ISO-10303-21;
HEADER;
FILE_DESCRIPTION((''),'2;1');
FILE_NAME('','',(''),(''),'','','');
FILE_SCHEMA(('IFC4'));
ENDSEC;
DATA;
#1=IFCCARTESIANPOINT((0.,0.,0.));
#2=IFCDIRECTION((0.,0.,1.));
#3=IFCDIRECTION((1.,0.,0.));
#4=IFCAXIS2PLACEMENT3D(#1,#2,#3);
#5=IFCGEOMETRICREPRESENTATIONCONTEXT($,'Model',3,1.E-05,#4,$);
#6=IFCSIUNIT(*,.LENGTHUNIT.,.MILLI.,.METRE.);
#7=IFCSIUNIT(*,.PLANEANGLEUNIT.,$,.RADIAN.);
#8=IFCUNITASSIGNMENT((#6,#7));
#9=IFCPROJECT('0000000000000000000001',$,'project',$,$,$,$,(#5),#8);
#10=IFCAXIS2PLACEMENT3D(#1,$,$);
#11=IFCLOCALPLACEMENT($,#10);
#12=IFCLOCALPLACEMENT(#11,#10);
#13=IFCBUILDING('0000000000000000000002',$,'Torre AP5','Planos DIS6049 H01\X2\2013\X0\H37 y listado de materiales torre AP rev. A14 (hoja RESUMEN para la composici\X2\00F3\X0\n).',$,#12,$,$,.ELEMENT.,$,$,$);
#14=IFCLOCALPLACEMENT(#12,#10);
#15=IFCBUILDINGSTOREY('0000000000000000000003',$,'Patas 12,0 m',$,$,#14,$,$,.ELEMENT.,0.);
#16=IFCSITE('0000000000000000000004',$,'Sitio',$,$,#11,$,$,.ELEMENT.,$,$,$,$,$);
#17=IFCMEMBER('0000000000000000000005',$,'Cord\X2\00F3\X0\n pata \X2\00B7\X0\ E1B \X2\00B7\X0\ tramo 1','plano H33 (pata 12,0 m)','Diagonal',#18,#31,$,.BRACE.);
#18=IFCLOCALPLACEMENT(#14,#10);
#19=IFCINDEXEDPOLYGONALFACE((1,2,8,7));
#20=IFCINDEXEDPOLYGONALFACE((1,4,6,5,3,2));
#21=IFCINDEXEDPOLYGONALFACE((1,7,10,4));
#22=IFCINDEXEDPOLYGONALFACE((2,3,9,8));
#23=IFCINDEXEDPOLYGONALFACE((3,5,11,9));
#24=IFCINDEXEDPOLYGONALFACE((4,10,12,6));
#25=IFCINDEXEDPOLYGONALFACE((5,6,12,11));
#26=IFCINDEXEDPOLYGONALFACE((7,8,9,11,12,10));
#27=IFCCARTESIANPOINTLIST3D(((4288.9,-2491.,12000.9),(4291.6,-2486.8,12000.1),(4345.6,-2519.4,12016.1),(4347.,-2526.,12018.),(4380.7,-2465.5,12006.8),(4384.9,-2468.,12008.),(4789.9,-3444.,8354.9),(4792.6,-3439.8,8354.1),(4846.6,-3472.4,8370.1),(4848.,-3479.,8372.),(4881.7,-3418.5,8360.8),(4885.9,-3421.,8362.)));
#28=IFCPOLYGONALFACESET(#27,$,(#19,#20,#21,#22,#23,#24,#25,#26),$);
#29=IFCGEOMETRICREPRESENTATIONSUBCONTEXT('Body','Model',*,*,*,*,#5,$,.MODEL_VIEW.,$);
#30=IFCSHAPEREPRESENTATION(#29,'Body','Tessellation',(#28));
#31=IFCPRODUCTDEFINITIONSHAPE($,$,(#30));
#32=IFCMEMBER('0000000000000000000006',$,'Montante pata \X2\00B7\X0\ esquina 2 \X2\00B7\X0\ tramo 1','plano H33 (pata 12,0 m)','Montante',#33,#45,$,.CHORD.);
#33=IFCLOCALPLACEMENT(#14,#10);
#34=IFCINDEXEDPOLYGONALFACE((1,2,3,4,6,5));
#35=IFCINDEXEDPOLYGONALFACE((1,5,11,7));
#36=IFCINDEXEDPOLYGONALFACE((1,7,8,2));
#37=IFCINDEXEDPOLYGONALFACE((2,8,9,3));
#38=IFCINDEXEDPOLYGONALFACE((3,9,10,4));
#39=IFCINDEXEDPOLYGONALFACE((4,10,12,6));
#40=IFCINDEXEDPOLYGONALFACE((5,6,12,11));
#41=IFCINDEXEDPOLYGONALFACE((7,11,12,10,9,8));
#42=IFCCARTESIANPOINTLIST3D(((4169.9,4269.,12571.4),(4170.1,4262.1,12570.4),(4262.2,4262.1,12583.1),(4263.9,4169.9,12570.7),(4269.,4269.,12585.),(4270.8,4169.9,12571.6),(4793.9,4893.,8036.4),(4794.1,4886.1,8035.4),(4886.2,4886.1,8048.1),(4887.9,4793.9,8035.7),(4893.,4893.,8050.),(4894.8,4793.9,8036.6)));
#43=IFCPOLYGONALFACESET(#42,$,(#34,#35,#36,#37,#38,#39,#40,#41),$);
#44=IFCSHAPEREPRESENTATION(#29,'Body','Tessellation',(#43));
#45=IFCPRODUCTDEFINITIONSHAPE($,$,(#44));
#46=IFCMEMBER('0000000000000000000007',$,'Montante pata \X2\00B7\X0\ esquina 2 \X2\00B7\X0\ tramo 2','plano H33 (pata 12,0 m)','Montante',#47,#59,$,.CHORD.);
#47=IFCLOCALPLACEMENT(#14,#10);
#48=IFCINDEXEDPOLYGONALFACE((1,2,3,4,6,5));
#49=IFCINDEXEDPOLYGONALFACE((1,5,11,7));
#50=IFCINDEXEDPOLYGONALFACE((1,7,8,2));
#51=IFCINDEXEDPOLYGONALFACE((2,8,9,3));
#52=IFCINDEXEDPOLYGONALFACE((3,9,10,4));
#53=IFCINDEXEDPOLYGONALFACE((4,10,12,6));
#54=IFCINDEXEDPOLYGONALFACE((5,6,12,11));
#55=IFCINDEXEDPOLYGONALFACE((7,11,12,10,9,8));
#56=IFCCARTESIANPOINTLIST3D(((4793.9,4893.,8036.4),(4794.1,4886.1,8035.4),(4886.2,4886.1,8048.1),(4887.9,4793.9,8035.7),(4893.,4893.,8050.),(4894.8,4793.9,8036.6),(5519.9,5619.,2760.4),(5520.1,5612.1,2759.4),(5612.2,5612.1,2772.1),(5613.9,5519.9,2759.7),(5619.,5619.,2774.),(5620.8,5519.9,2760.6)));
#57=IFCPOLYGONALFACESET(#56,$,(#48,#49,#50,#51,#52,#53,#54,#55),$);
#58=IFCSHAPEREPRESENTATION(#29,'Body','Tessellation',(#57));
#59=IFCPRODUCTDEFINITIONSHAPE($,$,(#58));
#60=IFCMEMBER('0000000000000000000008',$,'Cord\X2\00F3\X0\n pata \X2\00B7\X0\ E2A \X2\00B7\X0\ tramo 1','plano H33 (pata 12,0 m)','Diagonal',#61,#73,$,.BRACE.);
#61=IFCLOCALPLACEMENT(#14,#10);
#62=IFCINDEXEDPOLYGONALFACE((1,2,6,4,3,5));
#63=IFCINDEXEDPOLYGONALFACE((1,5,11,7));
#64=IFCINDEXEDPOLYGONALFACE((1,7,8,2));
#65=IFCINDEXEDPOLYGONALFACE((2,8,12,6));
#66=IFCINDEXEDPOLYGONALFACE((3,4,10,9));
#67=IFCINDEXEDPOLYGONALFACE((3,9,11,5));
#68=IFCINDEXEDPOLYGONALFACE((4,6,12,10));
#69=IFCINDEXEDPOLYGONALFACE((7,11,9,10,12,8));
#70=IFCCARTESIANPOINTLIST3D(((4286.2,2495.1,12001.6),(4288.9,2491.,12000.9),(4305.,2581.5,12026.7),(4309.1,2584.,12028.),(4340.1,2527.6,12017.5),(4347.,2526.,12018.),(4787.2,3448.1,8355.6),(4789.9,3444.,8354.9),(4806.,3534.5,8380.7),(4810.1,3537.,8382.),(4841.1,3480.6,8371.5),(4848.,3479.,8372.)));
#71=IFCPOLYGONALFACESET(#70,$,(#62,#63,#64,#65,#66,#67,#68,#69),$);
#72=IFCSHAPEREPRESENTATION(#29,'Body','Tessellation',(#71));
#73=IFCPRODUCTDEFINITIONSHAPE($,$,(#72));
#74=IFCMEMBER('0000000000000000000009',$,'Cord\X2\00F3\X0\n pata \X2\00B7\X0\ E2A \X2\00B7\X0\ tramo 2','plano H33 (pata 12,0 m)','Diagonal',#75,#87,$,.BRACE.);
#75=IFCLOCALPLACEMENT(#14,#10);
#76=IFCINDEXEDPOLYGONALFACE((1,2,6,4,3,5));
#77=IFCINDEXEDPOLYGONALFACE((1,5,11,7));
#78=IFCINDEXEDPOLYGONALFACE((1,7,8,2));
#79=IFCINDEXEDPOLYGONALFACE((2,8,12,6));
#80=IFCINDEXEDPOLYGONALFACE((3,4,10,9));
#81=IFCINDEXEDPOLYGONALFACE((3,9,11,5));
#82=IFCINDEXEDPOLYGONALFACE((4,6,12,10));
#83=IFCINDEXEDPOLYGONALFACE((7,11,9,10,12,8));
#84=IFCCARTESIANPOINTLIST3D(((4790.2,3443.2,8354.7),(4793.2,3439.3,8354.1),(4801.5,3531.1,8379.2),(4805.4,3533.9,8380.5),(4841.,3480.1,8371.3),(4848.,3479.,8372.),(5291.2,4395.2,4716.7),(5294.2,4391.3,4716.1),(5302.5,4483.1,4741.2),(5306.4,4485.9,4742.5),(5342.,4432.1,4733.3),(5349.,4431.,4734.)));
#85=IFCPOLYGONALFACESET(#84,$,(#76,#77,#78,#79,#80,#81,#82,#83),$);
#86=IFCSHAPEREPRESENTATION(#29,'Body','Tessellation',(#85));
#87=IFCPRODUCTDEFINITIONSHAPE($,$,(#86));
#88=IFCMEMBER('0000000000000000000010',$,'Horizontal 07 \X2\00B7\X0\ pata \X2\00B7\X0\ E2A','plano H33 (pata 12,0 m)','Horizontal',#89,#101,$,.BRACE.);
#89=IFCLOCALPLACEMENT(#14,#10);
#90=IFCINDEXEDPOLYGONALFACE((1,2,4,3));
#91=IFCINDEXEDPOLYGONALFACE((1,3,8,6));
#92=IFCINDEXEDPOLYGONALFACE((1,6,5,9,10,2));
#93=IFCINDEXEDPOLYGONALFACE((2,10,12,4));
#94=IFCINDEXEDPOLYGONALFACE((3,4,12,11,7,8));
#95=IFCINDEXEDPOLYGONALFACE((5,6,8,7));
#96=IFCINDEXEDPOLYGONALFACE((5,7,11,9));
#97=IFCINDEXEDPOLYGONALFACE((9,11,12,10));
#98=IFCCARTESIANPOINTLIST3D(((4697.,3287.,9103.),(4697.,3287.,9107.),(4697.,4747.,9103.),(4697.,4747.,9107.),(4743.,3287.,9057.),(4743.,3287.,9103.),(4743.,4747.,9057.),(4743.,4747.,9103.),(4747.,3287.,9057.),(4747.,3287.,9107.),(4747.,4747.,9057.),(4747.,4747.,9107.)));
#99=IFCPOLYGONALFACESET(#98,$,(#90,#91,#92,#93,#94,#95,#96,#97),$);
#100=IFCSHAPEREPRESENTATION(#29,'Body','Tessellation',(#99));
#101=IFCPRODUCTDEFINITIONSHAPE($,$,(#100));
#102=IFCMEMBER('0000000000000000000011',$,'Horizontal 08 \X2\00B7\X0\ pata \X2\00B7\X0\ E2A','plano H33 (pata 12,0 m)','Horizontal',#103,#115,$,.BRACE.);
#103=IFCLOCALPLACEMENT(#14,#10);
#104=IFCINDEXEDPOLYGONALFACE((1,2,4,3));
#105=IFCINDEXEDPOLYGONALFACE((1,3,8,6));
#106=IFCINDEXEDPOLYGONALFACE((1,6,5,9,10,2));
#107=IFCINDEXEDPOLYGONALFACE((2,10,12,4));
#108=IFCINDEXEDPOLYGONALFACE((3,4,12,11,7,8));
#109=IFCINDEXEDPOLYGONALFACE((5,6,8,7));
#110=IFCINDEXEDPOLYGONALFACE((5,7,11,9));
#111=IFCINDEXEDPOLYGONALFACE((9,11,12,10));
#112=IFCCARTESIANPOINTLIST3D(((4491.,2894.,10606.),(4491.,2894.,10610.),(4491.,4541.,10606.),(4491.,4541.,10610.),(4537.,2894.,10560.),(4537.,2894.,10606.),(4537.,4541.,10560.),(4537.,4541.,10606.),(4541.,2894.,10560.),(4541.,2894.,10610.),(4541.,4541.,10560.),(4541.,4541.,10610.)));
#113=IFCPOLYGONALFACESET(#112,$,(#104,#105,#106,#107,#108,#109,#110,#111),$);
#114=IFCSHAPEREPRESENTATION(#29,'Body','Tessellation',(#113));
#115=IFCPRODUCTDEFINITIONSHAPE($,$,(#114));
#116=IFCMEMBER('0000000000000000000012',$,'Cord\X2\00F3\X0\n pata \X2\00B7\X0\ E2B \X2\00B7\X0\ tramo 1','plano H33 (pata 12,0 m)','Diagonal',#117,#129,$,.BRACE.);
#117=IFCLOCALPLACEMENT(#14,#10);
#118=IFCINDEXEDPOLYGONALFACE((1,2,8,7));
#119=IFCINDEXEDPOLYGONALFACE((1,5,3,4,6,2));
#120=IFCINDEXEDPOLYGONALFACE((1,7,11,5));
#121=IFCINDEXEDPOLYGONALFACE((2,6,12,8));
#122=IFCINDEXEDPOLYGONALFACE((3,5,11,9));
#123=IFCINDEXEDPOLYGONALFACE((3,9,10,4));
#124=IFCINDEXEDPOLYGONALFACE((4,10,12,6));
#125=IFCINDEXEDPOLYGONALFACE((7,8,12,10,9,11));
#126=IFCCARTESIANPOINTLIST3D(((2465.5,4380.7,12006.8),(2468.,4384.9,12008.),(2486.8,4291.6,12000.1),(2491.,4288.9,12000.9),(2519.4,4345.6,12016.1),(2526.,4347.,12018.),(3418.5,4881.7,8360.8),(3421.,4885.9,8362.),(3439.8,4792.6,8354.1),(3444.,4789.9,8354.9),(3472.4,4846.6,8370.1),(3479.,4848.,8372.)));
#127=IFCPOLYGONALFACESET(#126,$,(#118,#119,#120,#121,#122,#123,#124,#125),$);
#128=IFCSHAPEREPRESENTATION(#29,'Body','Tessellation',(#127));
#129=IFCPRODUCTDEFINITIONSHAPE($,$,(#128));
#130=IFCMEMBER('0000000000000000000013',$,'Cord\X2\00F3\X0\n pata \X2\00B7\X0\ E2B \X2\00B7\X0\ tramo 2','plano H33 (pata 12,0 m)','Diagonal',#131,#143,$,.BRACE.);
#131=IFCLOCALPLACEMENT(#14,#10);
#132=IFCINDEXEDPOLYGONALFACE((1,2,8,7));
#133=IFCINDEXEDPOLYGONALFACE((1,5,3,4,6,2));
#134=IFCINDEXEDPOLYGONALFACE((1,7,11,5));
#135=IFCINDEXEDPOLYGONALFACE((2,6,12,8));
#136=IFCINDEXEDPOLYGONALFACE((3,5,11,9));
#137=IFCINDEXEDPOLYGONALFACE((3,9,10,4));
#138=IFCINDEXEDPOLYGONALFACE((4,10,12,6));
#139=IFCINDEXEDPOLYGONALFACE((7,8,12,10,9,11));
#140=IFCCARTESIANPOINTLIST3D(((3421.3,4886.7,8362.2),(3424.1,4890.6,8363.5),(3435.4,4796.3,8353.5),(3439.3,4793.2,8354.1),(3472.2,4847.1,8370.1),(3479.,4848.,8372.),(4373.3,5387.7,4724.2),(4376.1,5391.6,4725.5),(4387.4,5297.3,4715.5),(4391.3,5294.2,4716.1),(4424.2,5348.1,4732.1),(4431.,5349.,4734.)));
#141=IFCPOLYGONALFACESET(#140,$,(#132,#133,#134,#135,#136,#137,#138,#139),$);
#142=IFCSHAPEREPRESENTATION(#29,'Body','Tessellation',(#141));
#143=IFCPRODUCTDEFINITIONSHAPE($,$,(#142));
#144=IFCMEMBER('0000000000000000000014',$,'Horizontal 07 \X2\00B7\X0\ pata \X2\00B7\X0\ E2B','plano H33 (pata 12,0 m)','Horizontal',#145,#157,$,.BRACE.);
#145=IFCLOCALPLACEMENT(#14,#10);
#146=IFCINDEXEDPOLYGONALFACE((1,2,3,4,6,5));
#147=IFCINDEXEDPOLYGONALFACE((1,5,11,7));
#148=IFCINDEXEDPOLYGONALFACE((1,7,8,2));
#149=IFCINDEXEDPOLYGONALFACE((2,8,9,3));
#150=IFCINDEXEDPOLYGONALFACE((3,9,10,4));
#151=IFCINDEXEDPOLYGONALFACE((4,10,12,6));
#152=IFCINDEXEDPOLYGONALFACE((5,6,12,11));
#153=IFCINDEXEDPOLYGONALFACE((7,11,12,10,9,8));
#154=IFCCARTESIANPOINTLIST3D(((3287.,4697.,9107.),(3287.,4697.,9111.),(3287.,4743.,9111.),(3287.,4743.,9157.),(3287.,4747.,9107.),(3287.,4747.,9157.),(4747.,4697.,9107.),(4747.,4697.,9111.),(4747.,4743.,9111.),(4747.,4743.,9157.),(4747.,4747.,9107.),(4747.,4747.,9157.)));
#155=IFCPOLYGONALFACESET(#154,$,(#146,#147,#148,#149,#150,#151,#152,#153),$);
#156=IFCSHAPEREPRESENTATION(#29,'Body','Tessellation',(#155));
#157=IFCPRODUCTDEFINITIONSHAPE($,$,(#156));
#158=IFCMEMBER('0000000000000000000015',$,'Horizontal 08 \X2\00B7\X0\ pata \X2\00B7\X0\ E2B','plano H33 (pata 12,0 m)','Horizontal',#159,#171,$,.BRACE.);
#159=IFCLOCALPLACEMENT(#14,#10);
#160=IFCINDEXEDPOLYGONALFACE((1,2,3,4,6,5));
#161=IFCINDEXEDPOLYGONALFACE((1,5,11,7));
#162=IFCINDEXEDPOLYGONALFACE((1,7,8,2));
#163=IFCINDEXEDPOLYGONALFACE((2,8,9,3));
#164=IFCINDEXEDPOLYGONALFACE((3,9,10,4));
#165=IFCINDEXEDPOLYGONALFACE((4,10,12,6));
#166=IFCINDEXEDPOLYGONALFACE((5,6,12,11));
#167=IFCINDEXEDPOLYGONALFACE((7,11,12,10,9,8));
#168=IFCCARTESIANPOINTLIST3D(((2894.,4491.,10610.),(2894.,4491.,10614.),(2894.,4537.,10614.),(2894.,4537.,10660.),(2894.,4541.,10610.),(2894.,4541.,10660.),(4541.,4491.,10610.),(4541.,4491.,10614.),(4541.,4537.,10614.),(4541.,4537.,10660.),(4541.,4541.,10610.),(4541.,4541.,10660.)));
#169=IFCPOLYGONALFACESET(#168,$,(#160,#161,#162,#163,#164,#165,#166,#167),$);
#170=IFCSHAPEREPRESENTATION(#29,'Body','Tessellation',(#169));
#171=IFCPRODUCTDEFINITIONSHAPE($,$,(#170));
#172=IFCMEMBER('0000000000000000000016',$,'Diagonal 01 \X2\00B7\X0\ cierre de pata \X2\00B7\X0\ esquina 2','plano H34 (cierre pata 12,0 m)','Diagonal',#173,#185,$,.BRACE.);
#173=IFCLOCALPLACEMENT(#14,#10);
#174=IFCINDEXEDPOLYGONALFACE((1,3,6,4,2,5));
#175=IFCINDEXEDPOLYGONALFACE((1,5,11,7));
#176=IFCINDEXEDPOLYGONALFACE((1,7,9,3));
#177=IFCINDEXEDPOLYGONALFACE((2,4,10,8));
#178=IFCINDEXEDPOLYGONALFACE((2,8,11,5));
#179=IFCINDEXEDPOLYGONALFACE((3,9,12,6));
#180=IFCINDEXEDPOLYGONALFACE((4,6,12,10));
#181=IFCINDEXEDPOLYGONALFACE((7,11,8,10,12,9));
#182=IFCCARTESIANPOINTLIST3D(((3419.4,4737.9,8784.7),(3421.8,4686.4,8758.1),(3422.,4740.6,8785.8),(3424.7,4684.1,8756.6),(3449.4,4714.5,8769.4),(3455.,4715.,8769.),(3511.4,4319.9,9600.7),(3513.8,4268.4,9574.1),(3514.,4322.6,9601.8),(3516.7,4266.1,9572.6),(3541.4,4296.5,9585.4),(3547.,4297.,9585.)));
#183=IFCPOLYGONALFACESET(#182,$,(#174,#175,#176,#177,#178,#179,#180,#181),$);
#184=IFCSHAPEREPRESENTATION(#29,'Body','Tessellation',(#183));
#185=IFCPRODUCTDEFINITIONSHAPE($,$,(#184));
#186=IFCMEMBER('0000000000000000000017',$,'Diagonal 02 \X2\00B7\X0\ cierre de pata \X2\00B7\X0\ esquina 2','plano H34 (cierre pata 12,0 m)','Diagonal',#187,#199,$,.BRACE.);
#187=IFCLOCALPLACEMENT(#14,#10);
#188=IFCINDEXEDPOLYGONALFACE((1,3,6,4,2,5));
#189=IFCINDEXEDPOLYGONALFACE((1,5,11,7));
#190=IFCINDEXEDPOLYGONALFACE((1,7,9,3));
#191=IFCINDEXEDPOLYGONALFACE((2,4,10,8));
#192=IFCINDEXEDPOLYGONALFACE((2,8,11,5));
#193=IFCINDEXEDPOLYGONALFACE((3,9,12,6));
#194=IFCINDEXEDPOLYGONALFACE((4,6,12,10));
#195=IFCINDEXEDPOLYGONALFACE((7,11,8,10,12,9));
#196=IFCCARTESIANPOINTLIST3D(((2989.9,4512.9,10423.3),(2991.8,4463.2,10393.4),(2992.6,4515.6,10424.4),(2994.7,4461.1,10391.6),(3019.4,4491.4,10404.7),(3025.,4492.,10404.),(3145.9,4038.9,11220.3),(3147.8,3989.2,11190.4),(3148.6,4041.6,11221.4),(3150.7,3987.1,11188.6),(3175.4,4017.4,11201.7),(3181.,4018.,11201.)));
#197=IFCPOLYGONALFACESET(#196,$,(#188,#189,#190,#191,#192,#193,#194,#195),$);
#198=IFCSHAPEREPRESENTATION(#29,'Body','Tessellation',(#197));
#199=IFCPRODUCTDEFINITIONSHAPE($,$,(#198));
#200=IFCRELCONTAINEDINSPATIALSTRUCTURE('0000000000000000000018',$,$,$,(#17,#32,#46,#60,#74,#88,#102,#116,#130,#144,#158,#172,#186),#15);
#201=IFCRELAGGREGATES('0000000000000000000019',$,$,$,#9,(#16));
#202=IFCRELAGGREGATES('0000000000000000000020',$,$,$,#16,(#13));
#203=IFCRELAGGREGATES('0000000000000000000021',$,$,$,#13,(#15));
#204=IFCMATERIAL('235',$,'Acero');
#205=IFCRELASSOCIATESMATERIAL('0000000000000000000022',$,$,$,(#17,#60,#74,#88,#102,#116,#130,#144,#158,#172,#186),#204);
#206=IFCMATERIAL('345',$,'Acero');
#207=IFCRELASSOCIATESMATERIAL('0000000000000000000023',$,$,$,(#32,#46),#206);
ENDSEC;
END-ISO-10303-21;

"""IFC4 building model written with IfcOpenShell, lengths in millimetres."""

from ifc_helpers import new_model, si_unit, frame, frame_2d, origin, origin_with_axes, place, context, subcontext, project, spatial, l_section, extrude, material, element, save


model = new_model("IFC4")

# Units and contexts
model_context = context("Model", 3, precision=1e-05, world=origin_with_axes())
body_context = subcontext(model_context, "Body", "Model", "MODEL_VIEW")
ifc_project = project(units=[si_unit("LENGTHUNIT", "METRE", prefix="MILLI"), si_unit("PLANEANGLEUNIT", "RADIAN")], contexts=[model_context])

# Site, building, storey
site_placement = place(None, origin())
site = spatial("IfcSite", under=ifc_project, at=site_placement, Name="Sitio", CompositionType="ELEMENT")
building_placement = place(site_placement, origin())
building = spatial("IfcBuilding", under=site, at=building_placement, Name="Torre AP5", Description="Planos DIS6049 H01–H37 y listado de materiales torre AP rev. A14 (hoja RESUMEN para la composición).", CompositionType="ELEMENT")
storey_placement = place(building_placement, origin())
storey = spatial("IfcBuildingStorey", under=building, at=storey_placement, Name="Patas 12,0 m", CompositionType="ELEMENT", Elevation=0.0)

# Members
ifc_material_1 = material(Name="235", Category="Acero")
member_1_placement = place(storey_placement, frame((4347.0, -2526.0, 12018.0), z_axis=(0.131785, -0.250681, -0.959058), x_axis=(-0.83048, 0.500329, -0.244894)))
element("IfcMember", 1, at=member_1_placement, inside=storey, material=ifc_material_1, Name="Cordón pata · E1B · tramo 1", Description="plano H33 (pata 12,0 m)", ObjectType="Diagonal", PredefinedType="BRACE", context=body_context, shape_type="SweptSolid", body=[
    extrude(l_section(Depth=70.0, Width=70.0, Thickness=5.0, at=frame_2d((35.0, 35.0))), None, (0.0, 0.0, 1.0), 3801.6),
])
ifc_material_2 = material(Name="345", Category="Acero")
member_2_placement = place(storey_placement, frame((4269.0, 4269.0, 12585.0), z_axis=(0.135063, 0.135063, -0.981588), x_axis=(0.018411, -0.990837, -0.133802)))
element("IfcMember", 2, at=member_2_placement, inside=storey, material=ifc_material_2, Name="Montante pata · esquina 2 · tramo 1", Description="plano H33 (pata 12,0 m)", ObjectType="Montante", PredefinedType="CHORD", context=body_context, shape_type="SweptSolid", body=[
    extrude(l_section(Depth=100.0, Width=100.0, Thickness=7.0, at=frame_2d((50.0, 50.0))), None, (0.0, 0.0, 1.0), 4620.1),
])
member_3_placement = place(storey_placement, frame((4893.0, 4893.0, 8050.0), z_axis=(0.13507, 0.13507, -0.981586), x_axis=(0.018413, -0.990836, -0.13381)))
element("IfcMember", 3, at=member_3_placement, inside=storey, material=ifc_material_2, Name="Montante pata · esquina 2 · tramo 2", Description="plano H33 (pata 12,0 m)", ObjectType="Montante", PredefinedType="CHORD", context=body_context, shape_type="SweptSolid", body=[
    extrude(l_section(Depth=100.0, Width=100.0, Thickness=7.0, at=frame_2d((50.0, 50.0))), None, (0.0, 0.0, 1.0), 5375.0),
])
member_4_placement = place(storey_placement, frame((4347.0, 2526.0, 12018.0), z_axis=(0.131785, 0.250681, -0.959058), x_axis=(-0.83048, -0.500329, -0.244894)))
element("IfcMember", 4, at=member_4_placement, inside=storey, material=ifc_material_1, Name="Cordón pata · E2A · tramo 1", Description="plano H33 (pata 12,0 m)", ObjectType="Diagonal", PredefinedType="BRACE", context=body_context, shape_type="SweptSolid", body=[
    extrude(l_section(Depth=70.0, Width=70.0, Thickness=5.0, at=frame_2d((35.0, 35.0))), None, (0.0, 0.0, 1.0), 3801.6),
])
member_5_placement = place(storey_placement, frame((4848.0, 3479.0, 8372.0), z_axis=(0.13206, 0.250941, -0.958952), x_axis=(-0.782575, -0.567377, -0.256243)))
element("IfcMember", 5, at=member_5_placement, inside=storey, material=ifc_material_1, Name="Cordón pata · E2A · tramo 2", Description="plano H33 (pata 12,0 m)", ObjectType="Diagonal", PredefinedType="BRACE", context=body_context, shape_type="SweptSolid", body=[
    extrude(l_section(Depth=70.0, Width=70.0, Thickness=5.0, at=frame_2d((35.0, 35.0))), None, (0.0, 0.0, 1.0), 3793.7),
])
member_6_placement = place(storey_placement, frame((4747.0, 4747.0, 9107.0), z_axis=(0.0, -1.0, 0.0), x_axis=(-1.0, 0.0, 0.0)))
element("IfcMember", 6, at=member_6_placement, inside=storey, material=ifc_material_1, Name="Horizontal 07 · pata · E2A", Description="plano H33 (pata 12,0 m)", ObjectType="Horizontal", PredefinedType="BRACE", context=body_context, shape_type="SweptSolid", body=[
    extrude(l_section(Depth=50.0, Width=50.0, Thickness=4.0, at=frame_2d((25.0, 25.0))), None, (0.0, 0.0, 1.0), 1460.0),
])
member_7_placement = place(storey_placement, frame((4541.0, 4541.0, 10610.0), z_axis=(0.0, -1.0, 0.0), x_axis=(-1.0, 0.0, 0.0)))
element("IfcMember", 7, at=member_7_placement, inside=storey, material=ifc_material_1, Name="Horizontal 08 · pata · E2A", Description="plano H33 (pata 12,0 m)", ObjectType="Horizontal", PredefinedType="BRACE", context=body_context, shape_type="SweptSolid", body=[
    extrude(l_section(Depth=50.0, Width=50.0, Thickness=4.0, at=frame_2d((25.0, 25.0))), None, (0.0, 0.0, 1.0), 1647.0),
])
member_8_placement = place(storey_placement, frame((2526.0, 4347.0, 12018.0), z_axis=(0.250681, 0.131785, -0.959058), x_axis=(-0.500329, -0.83048, -0.244894)))
element("IfcMember", 8, at=member_8_placement, inside=storey, material=ifc_material_1, Name="Cordón pata · E2B · tramo 1", Description="plano H33 (pata 12,0 m)", ObjectType="Diagonal", PredefinedType="BRACE", context=body_context, shape_type="SweptSolid", body=[
    extrude(l_section(Depth=70.0, Width=70.0, Thickness=5.0, at=frame_2d((35.0, 35.0))), None, (0.0, 0.0, 1.0), 3801.6),
])
member_9_placement = place(storey_placement, frame((3479.0, 4848.0, 8372.0), z_axis=(0.250941, 0.13206, -0.958952), x_axis=(-0.567377, -0.782575, -0.256243)))
element("IfcMember", 9, at=member_9_placement, inside=storey, material=ifc_material_1, Name="Cordón pata · E2B · tramo 2", Description="plano H33 (pata 12,0 m)", ObjectType="Diagonal", PredefinedType="BRACE", context=body_context, shape_type="SweptSolid", body=[
    extrude(l_section(Depth=70.0, Width=70.0, Thickness=5.0, at=frame_2d((35.0, 35.0))), None, (0.0, 0.0, 1.0), 3793.7),
])
member_10_placement = place(storey_placement, frame((4747.0, 4747.0, 9107.0), z_axis=(-1.0, 0.0, 0.0), x_axis=(0.0, -1.0, 0.0)))
element("IfcMember", 10, at=member_10_placement, inside=storey, material=ifc_material_1, Name="Horizontal 07 · pata · E2B", Description="plano H33 (pata 12,0 m)", ObjectType="Horizontal", PredefinedType="BRACE", context=body_context, shape_type="SweptSolid", body=[
    extrude(l_section(Depth=50.0, Width=50.0, Thickness=4.0, at=frame_2d((25.0, 25.0))), None, (0.0, 0.0, 1.0), 1460.0),
])
member_11_placement = place(storey_placement, frame((4541.0, 4541.0, 10610.0), z_axis=(-1.0, 0.0, 0.0), x_axis=(0.0, -1.0, 0.0)))
element("IfcMember", 11, at=member_11_placement, inside=storey, material=ifc_material_1, Name="Horizontal 08 · pata · E2B", Description="plano H33 (pata 12,0 m)", ObjectType="Horizontal", PredefinedType="BRACE", context=body_context, shape_type="SweptSolid", body=[
    extrude(l_section(Depth=50.0, Width=50.0, Thickness=4.0, at=frame_2d((25.0, 25.0))), None, (0.0, 0.0, 1.0), 1647.0),
])
member_12_placement = place(storey_placement, frame((3547.0, 4297.0, 9585.0), z_axis=(-0.099844, 0.45364, -0.885574), x_axis=(-0.673576, -0.68589, -0.275408)))
element("IfcMember", 12, at=member_12_placement, inside=storey, material=ifc_material_1, Name="Diagonal 01 · cierre de pata · esquina 2", Description="plano H34 (cierre pata 12,0 m)", ObjectType="Diagonal", PredefinedType="BRACE", context=body_context, shape_type="SweptSolid", body=[
    extrude(l_section(Depth=45.0, Width=45.0, Thickness=4.0, at=frame_2d((22.5, 22.5))), None, (0.0, 0.0, 1.0), 921.4),
])
member_13_placement = place(storey_placement, frame((3181.0, 4018.0, 11201.0), z_axis=(-0.165899, 0.504078, -0.847575), x_axis=(-0.673655, -0.685615, -0.275899)))
element("IfcMember", 13, at=member_13_placement, inside=storey, material=ifc_material_1, Name="Diagonal 02 · cierre de pata · esquina 2", Description="plano H34 (cierre pata 12,0 m)", ObjectType="Diagonal", PredefinedType="BRACE", context=body_context, shape_type="SweptSolid", body=[
    extrude(l_section(Depth=45.0, Width=45.0, Thickness=4.0, at=frame_2d((22.5, 22.5))), None, (0.0, 0.0, 1.0), 940.3),
])

save(model, "model.ifc")
